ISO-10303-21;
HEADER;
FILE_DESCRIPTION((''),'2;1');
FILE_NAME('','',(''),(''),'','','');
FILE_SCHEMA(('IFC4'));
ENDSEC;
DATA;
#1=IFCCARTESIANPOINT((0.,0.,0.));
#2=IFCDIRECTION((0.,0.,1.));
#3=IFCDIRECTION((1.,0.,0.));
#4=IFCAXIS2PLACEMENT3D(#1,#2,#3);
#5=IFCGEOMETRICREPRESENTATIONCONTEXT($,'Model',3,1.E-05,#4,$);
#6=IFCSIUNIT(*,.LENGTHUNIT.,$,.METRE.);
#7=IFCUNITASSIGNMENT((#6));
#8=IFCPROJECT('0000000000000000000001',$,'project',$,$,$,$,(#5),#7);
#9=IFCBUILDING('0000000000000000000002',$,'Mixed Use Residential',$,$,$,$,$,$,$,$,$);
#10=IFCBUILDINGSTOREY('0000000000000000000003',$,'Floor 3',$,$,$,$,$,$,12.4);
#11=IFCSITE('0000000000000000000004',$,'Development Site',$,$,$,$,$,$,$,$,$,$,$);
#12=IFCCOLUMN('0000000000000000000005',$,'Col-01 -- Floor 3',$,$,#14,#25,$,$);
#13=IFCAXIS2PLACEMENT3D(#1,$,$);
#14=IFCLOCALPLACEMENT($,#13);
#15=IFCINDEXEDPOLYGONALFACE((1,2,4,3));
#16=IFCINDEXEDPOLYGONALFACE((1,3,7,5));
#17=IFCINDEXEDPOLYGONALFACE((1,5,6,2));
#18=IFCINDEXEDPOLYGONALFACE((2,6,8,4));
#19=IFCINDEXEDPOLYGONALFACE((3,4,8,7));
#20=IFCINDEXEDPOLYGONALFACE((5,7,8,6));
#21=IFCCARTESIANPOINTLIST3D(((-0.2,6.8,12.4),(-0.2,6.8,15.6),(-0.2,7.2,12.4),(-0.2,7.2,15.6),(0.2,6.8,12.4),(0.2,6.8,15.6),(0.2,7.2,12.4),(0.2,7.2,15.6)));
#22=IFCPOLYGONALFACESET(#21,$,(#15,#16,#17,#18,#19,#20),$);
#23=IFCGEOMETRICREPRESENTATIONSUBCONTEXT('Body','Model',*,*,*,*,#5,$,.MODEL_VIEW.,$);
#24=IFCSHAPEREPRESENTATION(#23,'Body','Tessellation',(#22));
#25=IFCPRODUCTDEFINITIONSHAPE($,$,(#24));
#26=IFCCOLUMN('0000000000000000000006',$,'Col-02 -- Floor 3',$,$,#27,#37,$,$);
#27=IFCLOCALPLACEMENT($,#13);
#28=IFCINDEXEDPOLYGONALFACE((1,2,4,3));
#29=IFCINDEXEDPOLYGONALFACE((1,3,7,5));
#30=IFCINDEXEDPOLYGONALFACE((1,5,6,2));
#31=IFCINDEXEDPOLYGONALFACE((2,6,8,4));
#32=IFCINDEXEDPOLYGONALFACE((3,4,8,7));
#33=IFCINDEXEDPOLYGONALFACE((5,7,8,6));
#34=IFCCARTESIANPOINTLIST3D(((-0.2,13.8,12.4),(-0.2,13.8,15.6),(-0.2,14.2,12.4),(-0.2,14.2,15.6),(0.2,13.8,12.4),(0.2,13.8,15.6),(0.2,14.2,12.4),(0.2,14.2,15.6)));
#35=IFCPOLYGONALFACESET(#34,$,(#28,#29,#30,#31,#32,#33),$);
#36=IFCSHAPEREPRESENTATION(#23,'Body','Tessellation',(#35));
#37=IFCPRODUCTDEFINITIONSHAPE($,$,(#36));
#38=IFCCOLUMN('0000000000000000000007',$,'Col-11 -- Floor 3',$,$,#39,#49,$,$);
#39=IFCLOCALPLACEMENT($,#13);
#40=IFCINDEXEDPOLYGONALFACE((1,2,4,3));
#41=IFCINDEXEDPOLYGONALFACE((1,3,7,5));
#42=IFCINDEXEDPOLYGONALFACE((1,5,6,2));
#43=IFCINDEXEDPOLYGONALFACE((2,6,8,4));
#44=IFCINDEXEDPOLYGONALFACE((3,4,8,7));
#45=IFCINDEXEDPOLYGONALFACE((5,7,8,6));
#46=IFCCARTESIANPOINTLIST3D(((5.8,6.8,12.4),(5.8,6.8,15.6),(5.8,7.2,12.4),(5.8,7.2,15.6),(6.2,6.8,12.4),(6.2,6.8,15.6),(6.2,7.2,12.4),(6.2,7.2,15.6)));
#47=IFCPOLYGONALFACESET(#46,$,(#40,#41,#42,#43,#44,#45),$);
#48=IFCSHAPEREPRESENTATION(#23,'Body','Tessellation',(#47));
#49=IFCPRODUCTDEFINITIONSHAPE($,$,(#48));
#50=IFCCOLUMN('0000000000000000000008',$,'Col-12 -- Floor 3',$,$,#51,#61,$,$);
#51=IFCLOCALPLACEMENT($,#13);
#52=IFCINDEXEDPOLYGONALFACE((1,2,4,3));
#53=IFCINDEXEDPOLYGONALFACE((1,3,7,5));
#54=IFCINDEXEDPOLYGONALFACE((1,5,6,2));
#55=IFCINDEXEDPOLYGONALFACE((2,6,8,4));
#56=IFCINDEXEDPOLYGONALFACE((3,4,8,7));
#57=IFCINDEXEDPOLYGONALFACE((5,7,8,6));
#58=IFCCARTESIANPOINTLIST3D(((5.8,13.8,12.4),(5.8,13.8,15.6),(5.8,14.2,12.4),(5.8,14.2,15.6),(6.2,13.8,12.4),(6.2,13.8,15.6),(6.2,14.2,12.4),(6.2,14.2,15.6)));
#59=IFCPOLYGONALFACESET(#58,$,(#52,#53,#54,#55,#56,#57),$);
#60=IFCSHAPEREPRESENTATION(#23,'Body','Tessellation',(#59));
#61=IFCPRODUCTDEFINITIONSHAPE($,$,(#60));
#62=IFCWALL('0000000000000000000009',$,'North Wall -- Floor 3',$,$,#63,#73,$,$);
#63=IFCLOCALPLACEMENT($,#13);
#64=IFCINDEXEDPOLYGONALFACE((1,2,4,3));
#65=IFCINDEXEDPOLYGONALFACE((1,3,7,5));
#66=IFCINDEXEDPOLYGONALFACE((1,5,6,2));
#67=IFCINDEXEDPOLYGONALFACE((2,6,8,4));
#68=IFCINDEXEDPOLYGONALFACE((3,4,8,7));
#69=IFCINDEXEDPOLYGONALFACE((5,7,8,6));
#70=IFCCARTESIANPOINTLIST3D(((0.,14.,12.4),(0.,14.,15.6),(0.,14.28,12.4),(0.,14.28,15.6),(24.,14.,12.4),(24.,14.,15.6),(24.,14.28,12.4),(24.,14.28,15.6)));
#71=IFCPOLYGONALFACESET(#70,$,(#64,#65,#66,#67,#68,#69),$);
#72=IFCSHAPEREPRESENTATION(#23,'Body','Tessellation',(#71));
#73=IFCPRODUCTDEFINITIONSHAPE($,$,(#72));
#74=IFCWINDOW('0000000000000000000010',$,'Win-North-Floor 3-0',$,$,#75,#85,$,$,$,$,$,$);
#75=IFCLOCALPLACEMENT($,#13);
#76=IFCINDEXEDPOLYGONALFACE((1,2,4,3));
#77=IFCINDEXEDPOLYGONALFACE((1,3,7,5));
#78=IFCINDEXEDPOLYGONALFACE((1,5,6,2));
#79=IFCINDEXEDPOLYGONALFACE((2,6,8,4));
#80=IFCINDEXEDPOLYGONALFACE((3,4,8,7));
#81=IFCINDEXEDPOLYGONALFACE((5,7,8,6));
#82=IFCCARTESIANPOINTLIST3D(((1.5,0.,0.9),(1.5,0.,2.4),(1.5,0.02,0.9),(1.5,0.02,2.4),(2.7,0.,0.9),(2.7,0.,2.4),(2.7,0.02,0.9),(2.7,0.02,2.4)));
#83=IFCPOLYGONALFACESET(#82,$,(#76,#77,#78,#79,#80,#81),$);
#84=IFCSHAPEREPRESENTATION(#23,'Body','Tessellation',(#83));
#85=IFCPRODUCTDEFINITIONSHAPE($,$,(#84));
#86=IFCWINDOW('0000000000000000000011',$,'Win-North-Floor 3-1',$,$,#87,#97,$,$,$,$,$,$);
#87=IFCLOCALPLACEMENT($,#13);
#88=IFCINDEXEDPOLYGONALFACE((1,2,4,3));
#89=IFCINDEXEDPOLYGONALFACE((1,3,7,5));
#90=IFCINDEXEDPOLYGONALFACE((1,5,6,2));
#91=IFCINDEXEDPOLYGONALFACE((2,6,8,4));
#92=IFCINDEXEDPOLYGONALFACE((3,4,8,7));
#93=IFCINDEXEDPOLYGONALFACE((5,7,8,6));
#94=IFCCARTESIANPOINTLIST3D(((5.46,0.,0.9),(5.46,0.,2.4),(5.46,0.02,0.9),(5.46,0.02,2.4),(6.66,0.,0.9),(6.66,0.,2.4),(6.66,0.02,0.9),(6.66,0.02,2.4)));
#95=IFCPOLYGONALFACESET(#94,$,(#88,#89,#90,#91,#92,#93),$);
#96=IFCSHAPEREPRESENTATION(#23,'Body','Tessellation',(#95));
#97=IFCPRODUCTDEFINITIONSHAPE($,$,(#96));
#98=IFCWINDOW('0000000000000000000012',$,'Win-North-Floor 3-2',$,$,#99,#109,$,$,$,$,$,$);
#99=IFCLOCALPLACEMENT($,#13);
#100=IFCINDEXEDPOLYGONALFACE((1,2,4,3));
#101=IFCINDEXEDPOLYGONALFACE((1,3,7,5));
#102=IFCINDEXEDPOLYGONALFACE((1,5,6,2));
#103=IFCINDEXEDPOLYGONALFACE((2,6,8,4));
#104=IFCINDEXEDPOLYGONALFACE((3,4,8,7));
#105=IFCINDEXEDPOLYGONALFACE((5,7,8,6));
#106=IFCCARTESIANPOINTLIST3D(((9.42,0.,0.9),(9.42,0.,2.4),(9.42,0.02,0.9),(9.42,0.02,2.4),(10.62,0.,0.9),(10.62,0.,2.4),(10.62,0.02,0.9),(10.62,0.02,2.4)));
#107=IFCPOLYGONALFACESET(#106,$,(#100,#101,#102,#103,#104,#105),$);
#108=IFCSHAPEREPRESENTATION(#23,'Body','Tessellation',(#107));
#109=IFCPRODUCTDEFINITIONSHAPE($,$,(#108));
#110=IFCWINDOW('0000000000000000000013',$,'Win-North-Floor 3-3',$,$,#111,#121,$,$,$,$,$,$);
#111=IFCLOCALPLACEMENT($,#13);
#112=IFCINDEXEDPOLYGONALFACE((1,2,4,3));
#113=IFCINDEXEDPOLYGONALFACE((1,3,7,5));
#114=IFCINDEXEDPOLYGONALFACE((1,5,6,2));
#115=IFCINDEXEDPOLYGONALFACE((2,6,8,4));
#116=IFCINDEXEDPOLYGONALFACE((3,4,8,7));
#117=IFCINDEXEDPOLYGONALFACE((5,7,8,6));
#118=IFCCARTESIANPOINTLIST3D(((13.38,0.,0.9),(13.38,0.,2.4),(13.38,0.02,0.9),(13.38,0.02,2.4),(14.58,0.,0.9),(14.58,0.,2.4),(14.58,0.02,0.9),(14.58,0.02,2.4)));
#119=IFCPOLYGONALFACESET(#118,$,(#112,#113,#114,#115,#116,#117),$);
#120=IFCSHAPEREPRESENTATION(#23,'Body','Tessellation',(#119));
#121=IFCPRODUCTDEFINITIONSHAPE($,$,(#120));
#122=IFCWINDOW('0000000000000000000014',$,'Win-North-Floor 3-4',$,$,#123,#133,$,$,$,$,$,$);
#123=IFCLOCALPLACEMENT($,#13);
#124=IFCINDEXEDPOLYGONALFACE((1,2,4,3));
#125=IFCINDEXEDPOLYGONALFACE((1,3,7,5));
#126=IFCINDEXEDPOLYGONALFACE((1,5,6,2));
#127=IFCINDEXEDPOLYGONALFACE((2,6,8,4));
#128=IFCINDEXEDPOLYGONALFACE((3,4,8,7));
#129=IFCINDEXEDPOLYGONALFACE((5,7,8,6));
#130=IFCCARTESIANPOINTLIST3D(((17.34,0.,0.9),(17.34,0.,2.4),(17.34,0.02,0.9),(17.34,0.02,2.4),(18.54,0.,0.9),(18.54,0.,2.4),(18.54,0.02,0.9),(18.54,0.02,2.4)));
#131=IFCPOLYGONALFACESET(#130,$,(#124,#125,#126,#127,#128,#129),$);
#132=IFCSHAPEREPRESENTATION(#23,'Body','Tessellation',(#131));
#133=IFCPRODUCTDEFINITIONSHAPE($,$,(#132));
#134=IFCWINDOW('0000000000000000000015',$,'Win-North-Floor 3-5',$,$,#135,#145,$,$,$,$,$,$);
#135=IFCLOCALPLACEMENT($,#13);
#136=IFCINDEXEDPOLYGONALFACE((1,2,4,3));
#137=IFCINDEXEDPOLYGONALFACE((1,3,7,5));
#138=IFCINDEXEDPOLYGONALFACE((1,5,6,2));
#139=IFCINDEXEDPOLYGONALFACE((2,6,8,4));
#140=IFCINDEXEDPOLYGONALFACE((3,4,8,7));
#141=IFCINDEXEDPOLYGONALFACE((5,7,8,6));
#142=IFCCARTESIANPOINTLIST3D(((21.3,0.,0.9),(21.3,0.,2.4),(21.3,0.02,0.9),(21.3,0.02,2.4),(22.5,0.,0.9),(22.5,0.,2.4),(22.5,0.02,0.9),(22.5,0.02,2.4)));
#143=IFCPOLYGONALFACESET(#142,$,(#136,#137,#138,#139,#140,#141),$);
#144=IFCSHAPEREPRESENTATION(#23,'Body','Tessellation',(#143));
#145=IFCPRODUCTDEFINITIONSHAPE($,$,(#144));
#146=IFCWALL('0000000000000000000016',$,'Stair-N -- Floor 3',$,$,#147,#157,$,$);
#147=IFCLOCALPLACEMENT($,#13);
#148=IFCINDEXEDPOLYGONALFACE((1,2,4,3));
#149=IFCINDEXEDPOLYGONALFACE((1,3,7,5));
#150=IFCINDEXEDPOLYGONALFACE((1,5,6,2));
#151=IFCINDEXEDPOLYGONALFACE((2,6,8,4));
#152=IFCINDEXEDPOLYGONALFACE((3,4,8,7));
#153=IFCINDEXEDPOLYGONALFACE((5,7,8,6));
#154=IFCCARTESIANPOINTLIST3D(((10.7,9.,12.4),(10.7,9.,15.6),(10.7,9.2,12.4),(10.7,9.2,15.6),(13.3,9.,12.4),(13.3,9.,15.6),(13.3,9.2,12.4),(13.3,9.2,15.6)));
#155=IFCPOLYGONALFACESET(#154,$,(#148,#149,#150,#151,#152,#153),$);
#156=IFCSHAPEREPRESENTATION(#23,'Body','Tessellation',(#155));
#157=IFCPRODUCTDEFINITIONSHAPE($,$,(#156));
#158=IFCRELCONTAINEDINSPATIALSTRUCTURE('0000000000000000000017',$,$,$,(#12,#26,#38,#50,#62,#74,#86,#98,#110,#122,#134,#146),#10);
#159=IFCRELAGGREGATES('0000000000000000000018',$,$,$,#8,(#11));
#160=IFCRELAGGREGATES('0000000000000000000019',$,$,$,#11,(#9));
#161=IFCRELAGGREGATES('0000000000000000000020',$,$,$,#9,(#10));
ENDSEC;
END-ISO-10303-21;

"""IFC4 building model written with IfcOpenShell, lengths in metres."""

from ifc_helpers import new_model, si_unit, frame, origin_with_axes, place, context, subcontext, project, spatial, indexed_curve, rectangle, outline, extrude, element, fill, save


model = new_model("IFC4")

# Units and contexts
model_context = context("Model", 3, precision=1e-05, world=origin_with_axes())
body_context = subcontext(model_context, "Body", "Model", "MODEL_VIEW")
ifc_project = project(units=[si_unit("LENGTHUNIT", "METRE")], contexts=[model_context])

# Site, building, storey
site = spatial("IfcSite", under=ifc_project, Name="Development Site")
building = spatial("IfcBuilding", under=site, Name="Mixed Use Residential")
storey = spatial("IfcBuildingStorey", under=building, Name="Floor 3", Elevation=12.4)

# Columns
for number, where, z_axis, x_axis, name in (
    (1, (0.0, 7.0, 12.4), (0.0, 0.0, 1.0), (1.0, 0.0, 0.0), "Col-01 -- Floor 3"),
    (2, (0.0, 14.0, 12.4), (0.0, 0.0, 1.0), (1.0, 0.0, 0.0), "Col-02 -- Floor 3"),
    (3, (6.0, 7.0, 12.4), (0.0, 0.0, 1.0), (1.0, 0.0, 0.0), "Col-11 -- Floor 3"),
    (4, (6.0, 14.0, 12.4), (0.0, 0.0, 1.0), (1.0, 0.0, 0.0), "Col-12 -- Floor 3"),
):
    element("IfcColumn", number, at=place(None, frame(where, z_axis=z_axis, x_axis=x_axis)), inside=storey, Name=name, context=body_context, shape_type="SweptSolid", body=[
        extrude(rectangle(XDim=0.4, YDim=0.4), origin_with_axes(), (0.0, 0.0, 1.0), 3.2),
    ])

# Wall, openings, windows
wall_1_placement = place(None, frame((0.0, 14.0, 12.4), z_axis=(0.0, 0.0, 1.0), x_axis=(1.0, 0.0, 0.0)))
wall_1 = element("IfcWall", 5, at=wall_1_placement, inside=storey, Name="North Wall -- Floor 3", context=body_context, shape_type="SweptSolid", body=[
    extrude(outline(indexed_curve([(0.0, 0.0), (0.0, 0.28), (24.0, 0.28), (24.0, 0.0), (0.0, 0.0)], self_intersect=False)), origin_with_axes(), (0.0, 0.0, 1.0), 3.2),
])
opening_1_placement = place(wall_1_placement, frame((1.5, -14.0, -11.5), z_axis=(0.0, 0.0, 1.0), x_axis=(1.0, 0.0, 0.0)))
opening_1 = element("IfcOpeningElement", 6, at=opening_1_placement, cuts=wall_1, context=body_context, shape_type="SweptSolid", body=[
    extrude(outline(indexed_curve([(0.0, 0.0), (0.0, 0.28), (1.2, 0.28), (1.2, 0.0), (0.0, 0.0)], self_intersect=False)), origin_with_axes(), (0.0, 0.0, 1.0), 1.5),
])
opening_2_placement = place(wall_1_placement, frame((5.46, -14.0, -11.5), z_axis=(0.0, 0.0, 1.0), x_axis=(1.0, 0.0, 0.0)))
opening_2 = element("IfcOpeningElement", 7, at=opening_2_placement, cuts=wall_1, context=body_context, shape_type="SweptSolid", body=[
    extrude(outline(indexed_curve([(0.0, 0.0), (0.0, 0.28), (1.2, 0.28), (1.2, 0.0), (0.0, 0.0)], self_intersect=False)), origin_with_axes(), (0.0, 0.0, 1.0), 1.5),
])
opening_3_placement = place(wall_1_placement, frame((9.42, -14.0, -11.5), z_axis=(0.0, 0.0, 1.0), x_axis=(1.0, 0.0, 0.0)))
opening_3 = element("IfcOpeningElement", 8, at=opening_3_placement, cuts=wall_1, context=body_context, shape_type="SweptSolid", body=[
    extrude(outline(indexed_curve([(0.0, 0.0), (0.0, 0.28), (1.2, 0.28), (1.2, 0.0), (0.0, 0.0)], self_intersect=False)), origin_with_axes(), (0.0, 0.0, 1.0), 1.5),
])
opening_4_placement = place(wall_1_placement, frame((13.38, -14.0, -11.5), z_axis=(0.0, 0.0, 1.0), x_axis=(1.0, 0.0, 0.0)))
opening_4 = element("IfcOpeningElement", 9, at=opening_4_placement, cuts=wall_1, context=body_context, shape_type="SweptSolid", body=[
    extrude(outline(indexed_curve([(0.0, 0.0), (0.0, 0.28), (1.2, 0.28), (1.2, 0.0), (0.0, 0.0)], self_intersect=False)), origin_with_axes(), (0.0, 0.0, 1.0), 1.5),
])
opening_5_placement = place(wall_1_placement, frame((17.34, -14.0, -11.5), z_axis=(0.0, 0.0, 1.0), x_axis=(1.0, 0.0, 0.0)))
opening_5 = element("IfcOpeningElement", 10, at=opening_5_placement, cuts=wall_1, context=body_context, shape_type="SweptSolid", body=[
    extrude(outline(indexed_curve([(0.0, 0.0), (0.0, 0.28), (1.2, 0.28), (1.2, 0.0), (0.0, 0.0)], self_intersect=False)), origin_with_axes(), (0.0, 0.0, 1.0), 1.5),
])
opening_6_placement = place(wall_1_placement, frame((21.3, -14.0, -11.5), z_axis=(0.0, 0.0, 1.0), x_axis=(1.0, 0.0, 0.0)))
opening_6 = element("IfcOpeningElement", 11, at=opening_6_placement, cuts=wall_1, context=body_context, shape_type="SweptSolid", body=[
    extrude(outline(indexed_curve([(0.0, 0.0), (0.0, 0.28), (1.2, 0.28), (1.2, 0.0), (0.0, 0.0)], self_intersect=False)), origin_with_axes(), (0.0, 0.0, 1.0), 1.5),
])
window_1_placement = place(None, frame((1.5, 0.0, 0.9), z_axis=(0.0, 0.0, 1.0), x_axis=(1.0, 0.0, 0.0)))
window_1 = element("IfcWindow", 12, at=window_1_placement, inside=storey, Name="Win-North-Floor 3-0", context=body_context, shape_type="SweptSolid", body=[
    extrude(outline(indexed_curve([(0.0, 0.0), (0.0, 0.02), (1.2, 0.02), (1.2, 0.0), (0.0, 0.0)], self_intersect=False)), origin_with_axes(), (0.0, 0.0, 1.0), 1.5),
])
fill(opening_1, window_1)
window_2_placement = place(None, frame((5.46, 0.0, 0.9), z_axis=(0.0, 0.0, 1.0), x_axis=(1.0, 0.0, 0.0)))
window_2 = element("IfcWindow", 13, at=window_2_placement, inside=storey, Name="Win-North-Floor 3-1", context=body_context, shape_type="SweptSolid", body=[
    extrude(outline(indexed_curve([(0.0, 0.0), (0.0, 0.02), (1.2, 0.02), (1.2, 0.0), (0.0, 0.0)], self_intersect=False)), origin_with_axes(), (0.0, 0.0, 1.0), 1.5),
])
fill(opening_2, window_2)
window_3_placement = place(None, frame((9.42, 0.0, 0.9), z_axis=(0.0, 0.0, 1.0), x_axis=(1.0, 0.0, 0.0)))
window_3 = element("IfcWindow", 14, at=window_3_placement, inside=storey, Name="Win-North-Floor 3-2", context=body_context, shape_type="SweptSolid", body=[
    extrude(outline(indexed_curve([(0.0, 0.0), (0.0, 0.02), (1.2, 0.02), (1.2, 0.0), (0.0, 0.0)], self_intersect=False)), origin_with_axes(), (0.0, 0.0, 1.0), 1.5),
])
fill(opening_3, window_3)
window_4_placement = place(None, frame((13.38, 0.0, 0.9), z_axis=(0.0, 0.0, 1.0), x_axis=(1.0, 0.0, 0.0)))
window_4 = element("IfcWindow", 15, at=window_4_placement, inside=storey, Name="Win-North-Floor 3-3", context=body_context, shape_type="SweptSolid", body=[
    extrude(outline(indexed_curve([(0.0, 0.0), (0.0, 0.02), (1.2, 0.02), (1.2, 0.0), (0.0, 0.0)], self_intersect=False)), origin_with_axes(), (0.0, 0.0, 1.0), 1.5),
])
fill(opening_4, window_4)
window_5_placement = place(None, frame((17.34, 0.0, 0.9), z_axis=(0.0, 0.0, 1.0), x_axis=(1.0, 0.0, 0.0)))
window_5 = element("IfcWindow", 16, at=window_5_placement, inside=storey, Name="Win-North-Floor 3-4", context=body_context, shape_type="SweptSolid", body=[
    extrude(outline(indexed_curve([(0.0, 0.0), (0.0, 0.02), (1.2, 0.02), (1.2, 0.0), (0.0, 0.0)], self_intersect=False)), origin_with_axes(), (0.0, 0.0, 1.0), 1.5),
])
fill(opening_5, window_5)
window_6_placement = place(None, frame((21.3, 0.0, 0.9), z_axis=(0.0, 0.0, 1.0), x_axis=(1.0, 0.0, 0.0)))
window_6 = element("IfcWindow", 17, at=window_6_placement, inside=storey, Name="Win-North-Floor 3-5", context=body_context, shape_type="SweptSolid", body=[
    extrude(outline(indexed_curve([(0.0, 0.0), (0.0, 0.02), (1.2, 0.02), (1.2, 0.0), (0.0, 0.0)], self_intersect=False)), origin_with_axes(), (0.0, 0.0, 1.0), 1.5),
])
fill(opening_6, window_6)

# Wall
wall_2_placement = place(None, frame((10.7, 9.0, 12.4), z_axis=(0.0, 0.0, 1.0), x_axis=(1.0, 0.0, 0.0)))
element("IfcWall", 18, at=wall_2_placement, inside=storey, Name="Stair-N -- Floor 3", context=body_context, shape_type="SweptSolid", body=[
    extrude(outline(indexed_curve([(0.0, 0.0), (0.0, 0.2), (2.6, 0.2), (2.6, 0.0), (0.0, 0.0)], self_intersect=False)), origin_with_axes(), (0.0, 0.0, 1.0), 3.2),
])

save(model, "model.ifc")
